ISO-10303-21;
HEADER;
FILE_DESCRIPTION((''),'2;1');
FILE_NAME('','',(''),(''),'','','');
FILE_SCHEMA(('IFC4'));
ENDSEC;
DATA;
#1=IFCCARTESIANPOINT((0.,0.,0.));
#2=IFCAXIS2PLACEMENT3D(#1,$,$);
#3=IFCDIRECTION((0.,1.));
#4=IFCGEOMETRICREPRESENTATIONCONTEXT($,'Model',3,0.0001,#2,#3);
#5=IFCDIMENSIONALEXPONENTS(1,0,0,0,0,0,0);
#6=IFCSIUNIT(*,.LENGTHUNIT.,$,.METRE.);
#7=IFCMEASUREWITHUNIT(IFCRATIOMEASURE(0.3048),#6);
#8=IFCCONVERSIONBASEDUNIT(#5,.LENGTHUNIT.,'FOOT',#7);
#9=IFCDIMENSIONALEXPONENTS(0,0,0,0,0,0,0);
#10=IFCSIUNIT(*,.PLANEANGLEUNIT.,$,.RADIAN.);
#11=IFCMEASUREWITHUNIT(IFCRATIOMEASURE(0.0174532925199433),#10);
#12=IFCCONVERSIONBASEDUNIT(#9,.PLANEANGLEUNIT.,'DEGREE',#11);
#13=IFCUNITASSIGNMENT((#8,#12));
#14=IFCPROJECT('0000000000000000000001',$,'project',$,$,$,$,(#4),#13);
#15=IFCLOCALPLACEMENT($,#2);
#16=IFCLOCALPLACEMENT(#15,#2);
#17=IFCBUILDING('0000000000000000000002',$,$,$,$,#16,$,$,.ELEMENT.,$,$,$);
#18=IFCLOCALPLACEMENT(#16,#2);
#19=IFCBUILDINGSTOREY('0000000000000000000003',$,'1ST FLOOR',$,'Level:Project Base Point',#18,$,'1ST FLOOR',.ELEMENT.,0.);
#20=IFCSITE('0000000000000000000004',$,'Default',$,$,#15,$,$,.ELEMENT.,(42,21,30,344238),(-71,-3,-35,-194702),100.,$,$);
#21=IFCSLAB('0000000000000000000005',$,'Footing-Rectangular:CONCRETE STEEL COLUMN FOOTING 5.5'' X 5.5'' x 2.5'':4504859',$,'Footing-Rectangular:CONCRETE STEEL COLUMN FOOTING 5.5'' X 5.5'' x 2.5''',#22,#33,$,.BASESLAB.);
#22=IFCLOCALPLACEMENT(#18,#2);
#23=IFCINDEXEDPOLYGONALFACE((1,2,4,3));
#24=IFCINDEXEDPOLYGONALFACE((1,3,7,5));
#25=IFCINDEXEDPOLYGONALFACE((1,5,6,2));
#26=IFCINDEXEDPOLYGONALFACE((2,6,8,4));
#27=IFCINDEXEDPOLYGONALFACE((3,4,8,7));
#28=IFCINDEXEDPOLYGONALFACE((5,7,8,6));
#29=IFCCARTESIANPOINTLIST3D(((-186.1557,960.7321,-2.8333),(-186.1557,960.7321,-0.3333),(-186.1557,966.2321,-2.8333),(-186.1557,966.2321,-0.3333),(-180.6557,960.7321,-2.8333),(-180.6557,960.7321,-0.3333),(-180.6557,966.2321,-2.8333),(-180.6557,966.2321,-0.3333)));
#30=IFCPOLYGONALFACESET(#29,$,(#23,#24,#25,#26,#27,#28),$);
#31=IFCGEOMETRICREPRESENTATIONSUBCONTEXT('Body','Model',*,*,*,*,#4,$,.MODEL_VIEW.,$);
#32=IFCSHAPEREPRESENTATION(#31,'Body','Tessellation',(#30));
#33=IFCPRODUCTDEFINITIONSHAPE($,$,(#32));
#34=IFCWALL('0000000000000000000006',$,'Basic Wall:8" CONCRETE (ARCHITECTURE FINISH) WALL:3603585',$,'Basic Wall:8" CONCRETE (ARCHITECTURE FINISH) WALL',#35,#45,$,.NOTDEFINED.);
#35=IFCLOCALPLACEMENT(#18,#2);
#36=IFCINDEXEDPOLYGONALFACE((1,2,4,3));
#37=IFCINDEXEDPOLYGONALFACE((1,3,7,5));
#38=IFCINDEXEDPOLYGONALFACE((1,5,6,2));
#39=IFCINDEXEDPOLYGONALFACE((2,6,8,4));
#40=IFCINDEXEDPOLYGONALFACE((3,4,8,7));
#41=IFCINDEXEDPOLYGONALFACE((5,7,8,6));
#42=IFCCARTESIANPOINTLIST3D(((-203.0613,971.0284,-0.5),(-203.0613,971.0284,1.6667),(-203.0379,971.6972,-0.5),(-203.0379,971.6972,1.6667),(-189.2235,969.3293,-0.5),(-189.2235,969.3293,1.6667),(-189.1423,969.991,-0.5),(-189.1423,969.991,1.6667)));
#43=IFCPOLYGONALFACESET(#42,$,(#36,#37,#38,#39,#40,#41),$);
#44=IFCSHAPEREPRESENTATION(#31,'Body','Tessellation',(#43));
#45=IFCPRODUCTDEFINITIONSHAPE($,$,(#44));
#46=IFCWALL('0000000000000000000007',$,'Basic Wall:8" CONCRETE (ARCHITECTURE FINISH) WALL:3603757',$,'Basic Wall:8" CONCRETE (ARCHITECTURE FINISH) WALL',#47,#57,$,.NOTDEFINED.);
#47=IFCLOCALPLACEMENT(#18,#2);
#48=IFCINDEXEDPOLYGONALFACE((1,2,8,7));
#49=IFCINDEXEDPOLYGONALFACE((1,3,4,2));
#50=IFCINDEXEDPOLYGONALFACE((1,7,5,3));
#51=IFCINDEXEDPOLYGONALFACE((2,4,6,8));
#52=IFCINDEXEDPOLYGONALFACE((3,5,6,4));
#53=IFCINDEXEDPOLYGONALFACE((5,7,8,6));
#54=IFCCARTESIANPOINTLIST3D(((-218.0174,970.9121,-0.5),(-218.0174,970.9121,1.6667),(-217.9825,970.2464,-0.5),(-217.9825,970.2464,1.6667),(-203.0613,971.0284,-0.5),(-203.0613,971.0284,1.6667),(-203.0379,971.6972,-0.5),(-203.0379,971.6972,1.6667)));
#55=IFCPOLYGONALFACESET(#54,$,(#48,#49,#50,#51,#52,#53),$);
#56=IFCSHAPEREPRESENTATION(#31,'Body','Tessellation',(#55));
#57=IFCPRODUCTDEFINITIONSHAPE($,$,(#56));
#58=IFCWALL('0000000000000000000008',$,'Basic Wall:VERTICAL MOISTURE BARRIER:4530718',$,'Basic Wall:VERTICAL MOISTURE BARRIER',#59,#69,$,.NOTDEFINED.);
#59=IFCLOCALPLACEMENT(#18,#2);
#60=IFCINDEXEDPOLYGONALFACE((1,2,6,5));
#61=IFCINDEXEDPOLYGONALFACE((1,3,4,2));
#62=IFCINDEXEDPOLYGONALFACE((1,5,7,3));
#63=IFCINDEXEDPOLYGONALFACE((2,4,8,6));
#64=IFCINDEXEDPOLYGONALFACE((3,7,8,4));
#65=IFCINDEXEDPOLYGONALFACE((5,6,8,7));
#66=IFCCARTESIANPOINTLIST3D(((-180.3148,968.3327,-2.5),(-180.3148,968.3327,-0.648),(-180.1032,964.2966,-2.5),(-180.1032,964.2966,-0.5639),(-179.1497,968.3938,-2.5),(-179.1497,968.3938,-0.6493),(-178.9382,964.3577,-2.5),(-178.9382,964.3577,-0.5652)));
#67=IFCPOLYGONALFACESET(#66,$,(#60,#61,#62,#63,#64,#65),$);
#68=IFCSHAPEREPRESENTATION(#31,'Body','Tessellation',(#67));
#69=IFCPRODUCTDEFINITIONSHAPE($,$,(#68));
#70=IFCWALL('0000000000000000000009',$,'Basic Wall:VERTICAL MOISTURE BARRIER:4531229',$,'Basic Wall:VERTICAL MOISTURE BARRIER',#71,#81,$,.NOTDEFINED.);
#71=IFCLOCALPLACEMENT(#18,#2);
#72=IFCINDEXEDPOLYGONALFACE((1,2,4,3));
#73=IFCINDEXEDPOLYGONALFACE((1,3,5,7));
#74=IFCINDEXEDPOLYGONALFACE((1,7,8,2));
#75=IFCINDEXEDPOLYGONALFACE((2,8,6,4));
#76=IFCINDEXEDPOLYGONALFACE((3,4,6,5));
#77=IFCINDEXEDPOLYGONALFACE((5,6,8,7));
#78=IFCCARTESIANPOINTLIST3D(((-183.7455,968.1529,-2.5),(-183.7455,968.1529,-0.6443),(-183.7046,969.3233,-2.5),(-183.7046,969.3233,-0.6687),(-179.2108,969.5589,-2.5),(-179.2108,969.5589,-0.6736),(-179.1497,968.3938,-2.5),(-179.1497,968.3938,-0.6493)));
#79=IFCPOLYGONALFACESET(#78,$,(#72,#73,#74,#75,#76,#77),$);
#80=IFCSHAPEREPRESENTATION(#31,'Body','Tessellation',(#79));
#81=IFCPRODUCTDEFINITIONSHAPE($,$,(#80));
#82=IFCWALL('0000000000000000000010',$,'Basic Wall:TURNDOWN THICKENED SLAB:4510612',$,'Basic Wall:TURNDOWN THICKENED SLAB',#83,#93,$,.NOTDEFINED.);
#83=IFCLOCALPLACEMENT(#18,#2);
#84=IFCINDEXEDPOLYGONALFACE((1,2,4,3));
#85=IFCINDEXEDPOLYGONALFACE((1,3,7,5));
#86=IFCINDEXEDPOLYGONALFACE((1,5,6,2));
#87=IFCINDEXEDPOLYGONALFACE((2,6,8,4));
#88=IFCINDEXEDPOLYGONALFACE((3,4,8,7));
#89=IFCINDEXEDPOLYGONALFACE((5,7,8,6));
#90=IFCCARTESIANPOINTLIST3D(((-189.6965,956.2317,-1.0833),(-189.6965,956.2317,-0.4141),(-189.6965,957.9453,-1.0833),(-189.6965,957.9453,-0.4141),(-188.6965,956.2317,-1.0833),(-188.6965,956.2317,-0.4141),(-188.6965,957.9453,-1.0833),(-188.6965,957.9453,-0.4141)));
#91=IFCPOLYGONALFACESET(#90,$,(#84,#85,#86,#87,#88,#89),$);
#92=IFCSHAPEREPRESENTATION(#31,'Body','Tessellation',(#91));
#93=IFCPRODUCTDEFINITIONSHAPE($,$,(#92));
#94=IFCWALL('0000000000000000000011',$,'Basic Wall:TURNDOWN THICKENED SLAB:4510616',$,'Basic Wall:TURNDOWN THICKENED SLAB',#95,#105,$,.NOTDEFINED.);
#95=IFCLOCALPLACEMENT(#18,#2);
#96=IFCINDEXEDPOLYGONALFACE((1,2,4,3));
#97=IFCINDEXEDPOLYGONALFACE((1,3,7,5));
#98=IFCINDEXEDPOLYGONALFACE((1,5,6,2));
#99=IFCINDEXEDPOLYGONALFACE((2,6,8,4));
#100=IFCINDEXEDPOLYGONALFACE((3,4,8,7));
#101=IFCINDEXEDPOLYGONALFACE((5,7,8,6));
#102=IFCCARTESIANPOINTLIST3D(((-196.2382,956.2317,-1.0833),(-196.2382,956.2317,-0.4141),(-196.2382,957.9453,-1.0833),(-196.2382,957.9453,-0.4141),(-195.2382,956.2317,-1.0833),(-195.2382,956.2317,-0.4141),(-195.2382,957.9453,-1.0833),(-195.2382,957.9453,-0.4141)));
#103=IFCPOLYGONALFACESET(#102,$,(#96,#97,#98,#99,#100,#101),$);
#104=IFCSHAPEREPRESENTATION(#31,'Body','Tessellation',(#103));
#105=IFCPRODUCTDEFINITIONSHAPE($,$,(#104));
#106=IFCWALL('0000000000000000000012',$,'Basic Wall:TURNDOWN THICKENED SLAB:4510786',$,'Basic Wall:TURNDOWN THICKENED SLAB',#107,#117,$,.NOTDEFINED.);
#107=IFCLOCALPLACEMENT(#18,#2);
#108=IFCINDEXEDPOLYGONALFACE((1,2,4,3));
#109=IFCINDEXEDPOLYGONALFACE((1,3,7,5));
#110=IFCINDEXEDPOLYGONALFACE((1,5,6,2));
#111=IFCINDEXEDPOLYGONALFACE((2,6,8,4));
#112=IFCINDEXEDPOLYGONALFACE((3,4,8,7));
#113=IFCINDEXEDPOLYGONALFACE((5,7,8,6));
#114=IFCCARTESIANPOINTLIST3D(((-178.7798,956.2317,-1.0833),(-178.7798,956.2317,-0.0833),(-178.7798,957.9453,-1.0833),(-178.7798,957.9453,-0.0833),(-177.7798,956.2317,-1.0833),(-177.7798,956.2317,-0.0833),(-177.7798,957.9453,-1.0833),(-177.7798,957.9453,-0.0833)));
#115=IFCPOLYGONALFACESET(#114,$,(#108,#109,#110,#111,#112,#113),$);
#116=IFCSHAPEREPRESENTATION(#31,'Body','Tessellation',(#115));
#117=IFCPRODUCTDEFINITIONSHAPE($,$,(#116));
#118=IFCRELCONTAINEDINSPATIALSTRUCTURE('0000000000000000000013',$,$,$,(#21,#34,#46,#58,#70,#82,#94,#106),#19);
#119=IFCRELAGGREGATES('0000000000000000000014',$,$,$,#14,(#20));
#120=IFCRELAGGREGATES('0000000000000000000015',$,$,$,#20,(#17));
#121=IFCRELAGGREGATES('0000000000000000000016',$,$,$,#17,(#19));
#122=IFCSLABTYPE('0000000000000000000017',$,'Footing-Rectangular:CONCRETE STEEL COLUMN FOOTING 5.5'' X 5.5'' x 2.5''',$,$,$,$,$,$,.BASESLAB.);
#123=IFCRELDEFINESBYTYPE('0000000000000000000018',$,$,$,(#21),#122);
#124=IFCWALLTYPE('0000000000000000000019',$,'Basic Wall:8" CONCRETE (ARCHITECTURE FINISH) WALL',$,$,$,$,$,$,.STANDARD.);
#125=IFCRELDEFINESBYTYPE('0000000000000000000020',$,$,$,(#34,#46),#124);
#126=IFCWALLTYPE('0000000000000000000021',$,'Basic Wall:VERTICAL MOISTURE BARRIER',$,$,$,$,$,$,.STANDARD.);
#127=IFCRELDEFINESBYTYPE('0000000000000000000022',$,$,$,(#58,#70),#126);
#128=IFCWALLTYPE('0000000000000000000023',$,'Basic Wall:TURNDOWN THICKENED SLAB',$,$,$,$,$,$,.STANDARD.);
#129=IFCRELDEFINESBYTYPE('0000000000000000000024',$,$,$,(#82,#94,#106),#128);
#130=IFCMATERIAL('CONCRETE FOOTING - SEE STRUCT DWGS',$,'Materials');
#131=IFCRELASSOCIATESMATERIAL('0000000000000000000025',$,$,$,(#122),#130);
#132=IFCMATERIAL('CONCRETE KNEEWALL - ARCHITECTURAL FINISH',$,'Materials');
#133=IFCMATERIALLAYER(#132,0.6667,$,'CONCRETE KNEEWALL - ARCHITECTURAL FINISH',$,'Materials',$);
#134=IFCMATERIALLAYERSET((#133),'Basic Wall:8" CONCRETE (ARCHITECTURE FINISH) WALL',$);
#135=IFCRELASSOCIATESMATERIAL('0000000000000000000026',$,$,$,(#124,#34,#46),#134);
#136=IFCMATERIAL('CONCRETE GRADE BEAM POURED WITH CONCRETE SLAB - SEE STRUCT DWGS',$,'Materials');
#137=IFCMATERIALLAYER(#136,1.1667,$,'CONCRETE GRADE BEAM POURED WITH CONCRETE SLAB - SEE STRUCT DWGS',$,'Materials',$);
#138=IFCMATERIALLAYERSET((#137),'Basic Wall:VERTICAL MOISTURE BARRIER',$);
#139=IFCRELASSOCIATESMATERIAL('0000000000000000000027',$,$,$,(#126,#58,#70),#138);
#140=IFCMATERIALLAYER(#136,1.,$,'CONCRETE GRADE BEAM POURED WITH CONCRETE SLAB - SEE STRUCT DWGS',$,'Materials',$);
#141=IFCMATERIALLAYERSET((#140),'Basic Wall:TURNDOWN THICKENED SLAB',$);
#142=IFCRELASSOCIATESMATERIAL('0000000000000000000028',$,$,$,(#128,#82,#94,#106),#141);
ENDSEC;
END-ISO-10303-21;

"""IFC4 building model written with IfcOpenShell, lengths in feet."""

from ifc_helpers import new_model, entity, si_unit, converted_unit, direction, frame, frame_2d, origin, place, context, subcontext, project, spatial, polyline, rectangle, outline, extrude, clip, bounded_halfspace, material, layer, layer_set, layer_usage, type_object, element, save


model = new_model("IFC4")

# Units and contexts
model_context = context("Model", 3, precision=0.0001, world=origin(), true_north=direction((0.0, 1.0)))
body_context = subcontext(model_context, "Body", "Model", "MODEL_VIEW")
ifc_project = project(units=[converted_unit("LENGTHUNIT", "FOOT", entity("IfcRatioMeasure", 0.3048), si_unit("LENGTHUNIT", "METRE"), dimensions=[1, 0, 0, 0, 0, 0, 0]), converted_unit("PLANEANGLEUNIT", "DEGREE", entity("IfcRatioMeasure", 0.0174532925199433), si_unit("PLANEANGLEUNIT", "RADIAN"), dimensions=[0, 0, 0, 0, 0, 0, 0])], contexts=[model_context])

# Site, building, storey
site_placement = place(None, origin())
site = spatial("IfcSite", under=ifc_project, at=site_placement, Name="Default", CompositionType="ELEMENT", RefLatitude=(42, 21, 30, 344238), RefLongitude=(-71, -3, -35, -194702), RefElevation=100.0)
building_placement = place(site_placement, origin())
building = spatial("IfcBuilding", under=site, at=building_placement, CompositionType="ELEMENT")
storey_placement = place(building_placement, origin())
storey = spatial("IfcBuildingStorey", under=building, at=storey_placement, Name="1ST FLOOR", ObjectType="Level:Project Base Point", LongName="1ST FLOOR", CompositionType="ELEMENT", Elevation=0.0)

# Slab
ifc_material_1 = material(Name="CONCRETE FOOTING - SEE STRUCT DWGS", Category="Materials")
slab_type = type_object("IfcSlabType", Name="Footing-Rectangular:CONCRETE STEEL COLUMN FOOTING 5.5' X 5.5' x 2.5'", PredefinedType="BASESLAB", material=ifc_material_1)
slab_placement = place(storey_placement, frame((-186.1557, 960.7321, -2.8333)))
element("IfcSlab", 1, at=slab_placement, inside=storey, type_object=slab_type, Name="Footing-Rectangular:CONCRETE STEEL COLUMN FOOTING 5.5' X 5.5' x 2.5':4504859", ObjectType="Footing-Rectangular:CONCRETE STEEL COLUMN FOOTING 5.5' X 5.5' x 2.5'", PredefinedType="BASESLAB", context=body_context, shape_type="SweptSolid", body=[
    extrude(rectangle(XDim=5.5, YDim=5.5, at=frame_2d((0.0, 0.0), x_axis=(1.0, 0.0))), frame((2.75, 2.75, 0.0), z_axis=(0.0, 0.0, 1.0), x_axis=(-1.0, 0.0, 0.0)), (0.0, 0.0, 1.0), 2.5),
])

# Walls
ifc_material_2 = material(Name="CONCRETE KNEEWALL - ARCHITECTURAL FINISH", Category="Materials")
ifc_layer_1 = layer(ifc_material_2, 0.6667, Name="CONCRETE KNEEWALL - ARCHITECTURAL FINISH", Category="Materials")
ifc_layer_set_1 = layer_set([ifc_layer_1], Name="Basic Wall:8\" CONCRETE (ARCHITECTURE FINISH) WALL")
ifc_layer_usage_1 = layer_usage(ifc_layer_set_1, "AXIS2", "NEGATIVE", 0.3333)
wall_type_1 = type_object("IfcWallType", Name="Basic Wall:8\" CONCRETE (ARCHITECTURE FINISH) WALL", PredefinedType="STANDARD", material=ifc_layer_set_1)
wall_1_placement = place(storey_placement, frame((-189.1829, 969.6602, -0.5), z_axis=(0.0, 0.0, 1.0), x_axis=(-0.992546, 0.121869, 0.0)))
element("IfcWall", 2, at=wall_1_placement, inside=storey, type_object=wall_type_1, material=ifc_layer_usage_1, Name="Basic Wall:8\" CONCRETE (ARCHITECTURE FINISH) WALL:3603585", ObjectType="Basic Wall:8\" CONCRETE (ARCHITECTURE FINISH) WALL", PredefinedType="NOTDEFINED", context=body_context, shape_type="SweptSolid", body=[
    extrude(outline(polyline([(14.0, -0.3333), (13.9417, 0.3333), (0.0, 0.3333), (0.0, -0.3333), (14.0, -0.3333)])), origin(), (0.0, 0.0, 1.0), 2.1667),
])
ifc_layer_usage_2 = layer_usage(ifc_layer_set_1, "AXIS2", "NEGATIVE", 0.3333)
wall_2_placement = place(storey_placement, frame((-203.0205, 971.3643, -0.5), z_axis=(0.0, 0.0, 1.0), x_axis=(-0.99863, -0.052336, 0.0)))
element("IfcWall", 3, at=wall_2_placement, inside=storey, type_object=wall_type_1, material=ifc_layer_usage_2, Name="Basic Wall:8\" CONCRETE (ARCHITECTURE FINISH) WALL:3603757", ObjectType="Basic Wall:8\" CONCRETE (ARCHITECTURE FINISH) WALL", PredefinedType="NOTDEFINED", context=body_context, shape_type="SweptSolid", body=[
    extrude(outline(polyline([(15.0, -0.3333), (15.0, 0.3333), (0.0583, 0.3333), (0.0, -0.3333), (15.0, -0.3333)])), origin(), (0.0, 0.0, 1.0), 2.1667),
])
ifc_material_3 = material(Name="CONCRETE GRADE BEAM POURED WITH CONCRETE SLAB - SEE STRUCT DWGS", Category="Materials")
ifc_layer_2 = layer(ifc_material_3, 1.1667, Name="CONCRETE GRADE BEAM POURED WITH CONCRETE SLAB - SEE STRUCT DWGS", Category="Materials")
ifc_layer_set_2 = layer_set([ifc_layer_2], Name="Basic Wall:VERTICAL MOISTURE BARRIER")
ifc_layer_usage_3 = layer_usage(ifc_layer_set_2, "AXIS2", "POSITIVE", -0.5833)
wall_type_2 = type_object("IfcWallType", Name="Basic Wall:VERTICAL MOISTURE BARRIER", PredefinedType="STANDARD", material=ifc_layer_set_2)
wall_3_placement = place(storey_placement, frame((-179.5207, 964.3271, -2.5), z_axis=(0.0, 0.0, 1.0), x_axis=(-0.052336, 0.99863, 0.0)))
element("IfcWall", 4, at=wall_3_placement, inside=storey, type_object=wall_type_2, material=ifc_layer_usage_3, Name="Basic Wall:VERTICAL MOISTURE BARRIER:4530718", ObjectType="Basic Wall:VERTICAL MOISTURE BARRIER", PredefinedType="NOTDEFINED", context=body_context, shape_type="Clipping", body=[
    clip(extrude(rectangle(XDim=4.0417, YDim=1.1667, at=frame_2d((2.0208, 0.0), x_axis=(-1.0, 0.0))), origin(), (0.0, 0.0, 1.0), 1.9361), bounded_halfspace(frame((0.0, -0.5833, 1.9348), z_axis=(-0.0208, 0.00109, -0.999783), x_axis=(-0.998413, 0.052325, 0.020829)), True, frame((0.0, -0.5833, 1.9348)), polyline([(0.0, 0.0), (4.0417, 0.0), (4.0417, 1.1667), (0.0, 1.1667), (0.0, 0.0)]))),
])
ifc_layer_usage_4 = layer_usage(ifc_layer_set_2, "AXIS2", "POSITIVE", -0.5833)
wall_4_placement = place(storey_placement, frame((-179.1802, 968.9763, -2.5), z_axis=(0.0, 0.0, 1.0), x_axis=(-0.99863, -0.052336, 0.0)))
element("IfcWall", 5, at=wall_4_placement, inside=storey, type_object=wall_type_2, material=ifc_layer_usage_4, Name="Basic Wall:VERTICAL MOISTURE BARRIER:4531229", ObjectType="Basic Wall:VERTICAL MOISTURE BARRIER", PredefinedType="NOTDEFINED", context=body_context, shape_type="Clipping", body=[
    clip(extrude(outline(polyline([(4.5, -0.5833), (4.6021, 0.5833), (3.4265, 0.5833), (1.1667, 0.5833), (0.0, 0.5833), (0.0, -0.5833), (4.5, -0.5833)])), origin(), (0.0, 0.0, 1.0), 1.8557), bounded_halfspace(frame((0.0, -0.5833, 1.8264), z_axis=(0.00109, 0.0208, -0.999783), x_axis=(0.052325, 0.998413, 0.020829)), True, frame((0.0, -0.5833, 1.8264)), polyline([(0.0, 0.0), (4.5, 0.0), (4.6021, 1.1667), (3.4265, 1.1667), (1.1667, 1.1667), (0.0, 1.1667), (0.0, 0.0)]))),
])
ifc_layer_3 = layer(ifc_material_3, 1.0, Name="CONCRETE GRADE BEAM POURED WITH CONCRETE SLAB - SEE STRUCT DWGS", Category="Materials")
ifc_layer_set_3 = layer_set([ifc_layer_3], Name="Basic Wall:TURNDOWN THICKENED SLAB")
ifc_layer_usage_5 = layer_usage(ifc_layer_set_3, "AXIS2", "POSITIVE", -0.5)
wall_type_3 = type_object("IfcWallType", Name="Basic Wall:TURNDOWN THICKENED SLAB", PredefinedType="STANDARD", material=ifc_layer_set_3)
wall_5_placement = place(storey_placement, frame((-189.1965, 957.9453, -1.0833), z_axis=(0.0, 0.0, 1.0), x_axis=(0.0, -1.0, 0.0)))
element("IfcWall", 6, at=wall_5_placement, inside=storey, type_object=wall_type_3, material=ifc_layer_usage_5, Name="Basic Wall:TURNDOWN THICKENED SLAB:4510612", ObjectType="Basic Wall:TURNDOWN THICKENED SLAB", PredefinedType="NOTDEFINED", context=body_context, shape_type="Clipping", body=[
    clip(extrude(rectangle(XDim=1.7136, YDim=1.0, at=frame_2d((0.8568, 0.0), x_axis=(-1.0, 0.0))), origin(), (0.0, 0.0, 1.0), 0.6693), bounded_halfspace(frame((1.0833, -0.5, 0.6693), z_axis=(0.0, 0.0, -1.0), x_axis=(0.0, 1.0, 0.0)), True, frame((1.0833, -0.5, 0.6693), z_axis=(0.0, 0.0, -1.0), x_axis=(0.0, 1.0, 0.0)), polyline([(0.0, 0.0), (0.0, -1.0833), (1.0, -1.0833), (1.0, 0.6302), (0.0, 0.6302), (0.0, 0.0)]))),
])
ifc_layer_usage_6 = layer_usage(ifc_layer_set_3, "AXIS2", "NEGATIVE", 0.5)
wall_6_placement = place(storey_placement, frame((-195.7382, 957.9453, -1.0833), z_axis=(0.0, 0.0, 1.0), x_axis=(0.0, -1.0, 0.0)))
element("IfcWall", 7, at=wall_6_placement, inside=storey, type_object=wall_type_3, material=ifc_layer_usage_6, Name="Basic Wall:TURNDOWN THICKENED SLAB:4510616", ObjectType="Basic Wall:TURNDOWN THICKENED SLAB", PredefinedType="NOTDEFINED", context=body_context, shape_type="Clipping", body=[
    clip(extrude(rectangle(XDim=1.7136, YDim=1.0, at=frame_2d((0.8568, 0.0), x_axis=(-1.0, 0.0))), origin(), (0.0, 0.0, 1.0), 0.6693), bounded_halfspace(frame((0.0, -0.5, 0.6693), z_axis=(0.0, 0.0, -1.0), x_axis=(0.0, 1.0, 0.0)), True, frame((0.0, -0.5, 0.6693), z_axis=(0.0, 0.0, -1.0), x_axis=(0.0, 1.0, 0.0)), polyline([(0.0, 0.0), (1.0, 0.0), (1.0, 1.0833), (1.0, 1.7136), (0.0, 1.7136), (0.0, 0.0)]))),
])
ifc_layer_usage_7 = layer_usage(ifc_layer_set_3, "AXIS2", "NEGATIVE", 0.5)
wall_7_placement = place(storey_placement, frame((-178.2798, 957.9453, -1.0833), z_axis=(0.0, 0.0, 1.0), x_axis=(0.0, -1.0, 0.0)))
element("IfcWall", 8, at=wall_7_placement, inside=storey, type_object=wall_type_3, material=ifc_layer_usage_7, Name="Basic Wall:TURNDOWN THICKENED SLAB:4510786", ObjectType="Basic Wall:TURNDOWN THICKENED SLAB", PredefinedType="NOTDEFINED", context=body_context, shape_type="SweptSolid", body=[
    extrude(rectangle(XDim=1.7136, YDim=1.0, at=frame_2d((0.8568, 0.0), x_axis=(-1.0, 0.0))), origin(), (0.0, 0.0, 1.0), 1.0),
])

save(model, "model.ifc")
